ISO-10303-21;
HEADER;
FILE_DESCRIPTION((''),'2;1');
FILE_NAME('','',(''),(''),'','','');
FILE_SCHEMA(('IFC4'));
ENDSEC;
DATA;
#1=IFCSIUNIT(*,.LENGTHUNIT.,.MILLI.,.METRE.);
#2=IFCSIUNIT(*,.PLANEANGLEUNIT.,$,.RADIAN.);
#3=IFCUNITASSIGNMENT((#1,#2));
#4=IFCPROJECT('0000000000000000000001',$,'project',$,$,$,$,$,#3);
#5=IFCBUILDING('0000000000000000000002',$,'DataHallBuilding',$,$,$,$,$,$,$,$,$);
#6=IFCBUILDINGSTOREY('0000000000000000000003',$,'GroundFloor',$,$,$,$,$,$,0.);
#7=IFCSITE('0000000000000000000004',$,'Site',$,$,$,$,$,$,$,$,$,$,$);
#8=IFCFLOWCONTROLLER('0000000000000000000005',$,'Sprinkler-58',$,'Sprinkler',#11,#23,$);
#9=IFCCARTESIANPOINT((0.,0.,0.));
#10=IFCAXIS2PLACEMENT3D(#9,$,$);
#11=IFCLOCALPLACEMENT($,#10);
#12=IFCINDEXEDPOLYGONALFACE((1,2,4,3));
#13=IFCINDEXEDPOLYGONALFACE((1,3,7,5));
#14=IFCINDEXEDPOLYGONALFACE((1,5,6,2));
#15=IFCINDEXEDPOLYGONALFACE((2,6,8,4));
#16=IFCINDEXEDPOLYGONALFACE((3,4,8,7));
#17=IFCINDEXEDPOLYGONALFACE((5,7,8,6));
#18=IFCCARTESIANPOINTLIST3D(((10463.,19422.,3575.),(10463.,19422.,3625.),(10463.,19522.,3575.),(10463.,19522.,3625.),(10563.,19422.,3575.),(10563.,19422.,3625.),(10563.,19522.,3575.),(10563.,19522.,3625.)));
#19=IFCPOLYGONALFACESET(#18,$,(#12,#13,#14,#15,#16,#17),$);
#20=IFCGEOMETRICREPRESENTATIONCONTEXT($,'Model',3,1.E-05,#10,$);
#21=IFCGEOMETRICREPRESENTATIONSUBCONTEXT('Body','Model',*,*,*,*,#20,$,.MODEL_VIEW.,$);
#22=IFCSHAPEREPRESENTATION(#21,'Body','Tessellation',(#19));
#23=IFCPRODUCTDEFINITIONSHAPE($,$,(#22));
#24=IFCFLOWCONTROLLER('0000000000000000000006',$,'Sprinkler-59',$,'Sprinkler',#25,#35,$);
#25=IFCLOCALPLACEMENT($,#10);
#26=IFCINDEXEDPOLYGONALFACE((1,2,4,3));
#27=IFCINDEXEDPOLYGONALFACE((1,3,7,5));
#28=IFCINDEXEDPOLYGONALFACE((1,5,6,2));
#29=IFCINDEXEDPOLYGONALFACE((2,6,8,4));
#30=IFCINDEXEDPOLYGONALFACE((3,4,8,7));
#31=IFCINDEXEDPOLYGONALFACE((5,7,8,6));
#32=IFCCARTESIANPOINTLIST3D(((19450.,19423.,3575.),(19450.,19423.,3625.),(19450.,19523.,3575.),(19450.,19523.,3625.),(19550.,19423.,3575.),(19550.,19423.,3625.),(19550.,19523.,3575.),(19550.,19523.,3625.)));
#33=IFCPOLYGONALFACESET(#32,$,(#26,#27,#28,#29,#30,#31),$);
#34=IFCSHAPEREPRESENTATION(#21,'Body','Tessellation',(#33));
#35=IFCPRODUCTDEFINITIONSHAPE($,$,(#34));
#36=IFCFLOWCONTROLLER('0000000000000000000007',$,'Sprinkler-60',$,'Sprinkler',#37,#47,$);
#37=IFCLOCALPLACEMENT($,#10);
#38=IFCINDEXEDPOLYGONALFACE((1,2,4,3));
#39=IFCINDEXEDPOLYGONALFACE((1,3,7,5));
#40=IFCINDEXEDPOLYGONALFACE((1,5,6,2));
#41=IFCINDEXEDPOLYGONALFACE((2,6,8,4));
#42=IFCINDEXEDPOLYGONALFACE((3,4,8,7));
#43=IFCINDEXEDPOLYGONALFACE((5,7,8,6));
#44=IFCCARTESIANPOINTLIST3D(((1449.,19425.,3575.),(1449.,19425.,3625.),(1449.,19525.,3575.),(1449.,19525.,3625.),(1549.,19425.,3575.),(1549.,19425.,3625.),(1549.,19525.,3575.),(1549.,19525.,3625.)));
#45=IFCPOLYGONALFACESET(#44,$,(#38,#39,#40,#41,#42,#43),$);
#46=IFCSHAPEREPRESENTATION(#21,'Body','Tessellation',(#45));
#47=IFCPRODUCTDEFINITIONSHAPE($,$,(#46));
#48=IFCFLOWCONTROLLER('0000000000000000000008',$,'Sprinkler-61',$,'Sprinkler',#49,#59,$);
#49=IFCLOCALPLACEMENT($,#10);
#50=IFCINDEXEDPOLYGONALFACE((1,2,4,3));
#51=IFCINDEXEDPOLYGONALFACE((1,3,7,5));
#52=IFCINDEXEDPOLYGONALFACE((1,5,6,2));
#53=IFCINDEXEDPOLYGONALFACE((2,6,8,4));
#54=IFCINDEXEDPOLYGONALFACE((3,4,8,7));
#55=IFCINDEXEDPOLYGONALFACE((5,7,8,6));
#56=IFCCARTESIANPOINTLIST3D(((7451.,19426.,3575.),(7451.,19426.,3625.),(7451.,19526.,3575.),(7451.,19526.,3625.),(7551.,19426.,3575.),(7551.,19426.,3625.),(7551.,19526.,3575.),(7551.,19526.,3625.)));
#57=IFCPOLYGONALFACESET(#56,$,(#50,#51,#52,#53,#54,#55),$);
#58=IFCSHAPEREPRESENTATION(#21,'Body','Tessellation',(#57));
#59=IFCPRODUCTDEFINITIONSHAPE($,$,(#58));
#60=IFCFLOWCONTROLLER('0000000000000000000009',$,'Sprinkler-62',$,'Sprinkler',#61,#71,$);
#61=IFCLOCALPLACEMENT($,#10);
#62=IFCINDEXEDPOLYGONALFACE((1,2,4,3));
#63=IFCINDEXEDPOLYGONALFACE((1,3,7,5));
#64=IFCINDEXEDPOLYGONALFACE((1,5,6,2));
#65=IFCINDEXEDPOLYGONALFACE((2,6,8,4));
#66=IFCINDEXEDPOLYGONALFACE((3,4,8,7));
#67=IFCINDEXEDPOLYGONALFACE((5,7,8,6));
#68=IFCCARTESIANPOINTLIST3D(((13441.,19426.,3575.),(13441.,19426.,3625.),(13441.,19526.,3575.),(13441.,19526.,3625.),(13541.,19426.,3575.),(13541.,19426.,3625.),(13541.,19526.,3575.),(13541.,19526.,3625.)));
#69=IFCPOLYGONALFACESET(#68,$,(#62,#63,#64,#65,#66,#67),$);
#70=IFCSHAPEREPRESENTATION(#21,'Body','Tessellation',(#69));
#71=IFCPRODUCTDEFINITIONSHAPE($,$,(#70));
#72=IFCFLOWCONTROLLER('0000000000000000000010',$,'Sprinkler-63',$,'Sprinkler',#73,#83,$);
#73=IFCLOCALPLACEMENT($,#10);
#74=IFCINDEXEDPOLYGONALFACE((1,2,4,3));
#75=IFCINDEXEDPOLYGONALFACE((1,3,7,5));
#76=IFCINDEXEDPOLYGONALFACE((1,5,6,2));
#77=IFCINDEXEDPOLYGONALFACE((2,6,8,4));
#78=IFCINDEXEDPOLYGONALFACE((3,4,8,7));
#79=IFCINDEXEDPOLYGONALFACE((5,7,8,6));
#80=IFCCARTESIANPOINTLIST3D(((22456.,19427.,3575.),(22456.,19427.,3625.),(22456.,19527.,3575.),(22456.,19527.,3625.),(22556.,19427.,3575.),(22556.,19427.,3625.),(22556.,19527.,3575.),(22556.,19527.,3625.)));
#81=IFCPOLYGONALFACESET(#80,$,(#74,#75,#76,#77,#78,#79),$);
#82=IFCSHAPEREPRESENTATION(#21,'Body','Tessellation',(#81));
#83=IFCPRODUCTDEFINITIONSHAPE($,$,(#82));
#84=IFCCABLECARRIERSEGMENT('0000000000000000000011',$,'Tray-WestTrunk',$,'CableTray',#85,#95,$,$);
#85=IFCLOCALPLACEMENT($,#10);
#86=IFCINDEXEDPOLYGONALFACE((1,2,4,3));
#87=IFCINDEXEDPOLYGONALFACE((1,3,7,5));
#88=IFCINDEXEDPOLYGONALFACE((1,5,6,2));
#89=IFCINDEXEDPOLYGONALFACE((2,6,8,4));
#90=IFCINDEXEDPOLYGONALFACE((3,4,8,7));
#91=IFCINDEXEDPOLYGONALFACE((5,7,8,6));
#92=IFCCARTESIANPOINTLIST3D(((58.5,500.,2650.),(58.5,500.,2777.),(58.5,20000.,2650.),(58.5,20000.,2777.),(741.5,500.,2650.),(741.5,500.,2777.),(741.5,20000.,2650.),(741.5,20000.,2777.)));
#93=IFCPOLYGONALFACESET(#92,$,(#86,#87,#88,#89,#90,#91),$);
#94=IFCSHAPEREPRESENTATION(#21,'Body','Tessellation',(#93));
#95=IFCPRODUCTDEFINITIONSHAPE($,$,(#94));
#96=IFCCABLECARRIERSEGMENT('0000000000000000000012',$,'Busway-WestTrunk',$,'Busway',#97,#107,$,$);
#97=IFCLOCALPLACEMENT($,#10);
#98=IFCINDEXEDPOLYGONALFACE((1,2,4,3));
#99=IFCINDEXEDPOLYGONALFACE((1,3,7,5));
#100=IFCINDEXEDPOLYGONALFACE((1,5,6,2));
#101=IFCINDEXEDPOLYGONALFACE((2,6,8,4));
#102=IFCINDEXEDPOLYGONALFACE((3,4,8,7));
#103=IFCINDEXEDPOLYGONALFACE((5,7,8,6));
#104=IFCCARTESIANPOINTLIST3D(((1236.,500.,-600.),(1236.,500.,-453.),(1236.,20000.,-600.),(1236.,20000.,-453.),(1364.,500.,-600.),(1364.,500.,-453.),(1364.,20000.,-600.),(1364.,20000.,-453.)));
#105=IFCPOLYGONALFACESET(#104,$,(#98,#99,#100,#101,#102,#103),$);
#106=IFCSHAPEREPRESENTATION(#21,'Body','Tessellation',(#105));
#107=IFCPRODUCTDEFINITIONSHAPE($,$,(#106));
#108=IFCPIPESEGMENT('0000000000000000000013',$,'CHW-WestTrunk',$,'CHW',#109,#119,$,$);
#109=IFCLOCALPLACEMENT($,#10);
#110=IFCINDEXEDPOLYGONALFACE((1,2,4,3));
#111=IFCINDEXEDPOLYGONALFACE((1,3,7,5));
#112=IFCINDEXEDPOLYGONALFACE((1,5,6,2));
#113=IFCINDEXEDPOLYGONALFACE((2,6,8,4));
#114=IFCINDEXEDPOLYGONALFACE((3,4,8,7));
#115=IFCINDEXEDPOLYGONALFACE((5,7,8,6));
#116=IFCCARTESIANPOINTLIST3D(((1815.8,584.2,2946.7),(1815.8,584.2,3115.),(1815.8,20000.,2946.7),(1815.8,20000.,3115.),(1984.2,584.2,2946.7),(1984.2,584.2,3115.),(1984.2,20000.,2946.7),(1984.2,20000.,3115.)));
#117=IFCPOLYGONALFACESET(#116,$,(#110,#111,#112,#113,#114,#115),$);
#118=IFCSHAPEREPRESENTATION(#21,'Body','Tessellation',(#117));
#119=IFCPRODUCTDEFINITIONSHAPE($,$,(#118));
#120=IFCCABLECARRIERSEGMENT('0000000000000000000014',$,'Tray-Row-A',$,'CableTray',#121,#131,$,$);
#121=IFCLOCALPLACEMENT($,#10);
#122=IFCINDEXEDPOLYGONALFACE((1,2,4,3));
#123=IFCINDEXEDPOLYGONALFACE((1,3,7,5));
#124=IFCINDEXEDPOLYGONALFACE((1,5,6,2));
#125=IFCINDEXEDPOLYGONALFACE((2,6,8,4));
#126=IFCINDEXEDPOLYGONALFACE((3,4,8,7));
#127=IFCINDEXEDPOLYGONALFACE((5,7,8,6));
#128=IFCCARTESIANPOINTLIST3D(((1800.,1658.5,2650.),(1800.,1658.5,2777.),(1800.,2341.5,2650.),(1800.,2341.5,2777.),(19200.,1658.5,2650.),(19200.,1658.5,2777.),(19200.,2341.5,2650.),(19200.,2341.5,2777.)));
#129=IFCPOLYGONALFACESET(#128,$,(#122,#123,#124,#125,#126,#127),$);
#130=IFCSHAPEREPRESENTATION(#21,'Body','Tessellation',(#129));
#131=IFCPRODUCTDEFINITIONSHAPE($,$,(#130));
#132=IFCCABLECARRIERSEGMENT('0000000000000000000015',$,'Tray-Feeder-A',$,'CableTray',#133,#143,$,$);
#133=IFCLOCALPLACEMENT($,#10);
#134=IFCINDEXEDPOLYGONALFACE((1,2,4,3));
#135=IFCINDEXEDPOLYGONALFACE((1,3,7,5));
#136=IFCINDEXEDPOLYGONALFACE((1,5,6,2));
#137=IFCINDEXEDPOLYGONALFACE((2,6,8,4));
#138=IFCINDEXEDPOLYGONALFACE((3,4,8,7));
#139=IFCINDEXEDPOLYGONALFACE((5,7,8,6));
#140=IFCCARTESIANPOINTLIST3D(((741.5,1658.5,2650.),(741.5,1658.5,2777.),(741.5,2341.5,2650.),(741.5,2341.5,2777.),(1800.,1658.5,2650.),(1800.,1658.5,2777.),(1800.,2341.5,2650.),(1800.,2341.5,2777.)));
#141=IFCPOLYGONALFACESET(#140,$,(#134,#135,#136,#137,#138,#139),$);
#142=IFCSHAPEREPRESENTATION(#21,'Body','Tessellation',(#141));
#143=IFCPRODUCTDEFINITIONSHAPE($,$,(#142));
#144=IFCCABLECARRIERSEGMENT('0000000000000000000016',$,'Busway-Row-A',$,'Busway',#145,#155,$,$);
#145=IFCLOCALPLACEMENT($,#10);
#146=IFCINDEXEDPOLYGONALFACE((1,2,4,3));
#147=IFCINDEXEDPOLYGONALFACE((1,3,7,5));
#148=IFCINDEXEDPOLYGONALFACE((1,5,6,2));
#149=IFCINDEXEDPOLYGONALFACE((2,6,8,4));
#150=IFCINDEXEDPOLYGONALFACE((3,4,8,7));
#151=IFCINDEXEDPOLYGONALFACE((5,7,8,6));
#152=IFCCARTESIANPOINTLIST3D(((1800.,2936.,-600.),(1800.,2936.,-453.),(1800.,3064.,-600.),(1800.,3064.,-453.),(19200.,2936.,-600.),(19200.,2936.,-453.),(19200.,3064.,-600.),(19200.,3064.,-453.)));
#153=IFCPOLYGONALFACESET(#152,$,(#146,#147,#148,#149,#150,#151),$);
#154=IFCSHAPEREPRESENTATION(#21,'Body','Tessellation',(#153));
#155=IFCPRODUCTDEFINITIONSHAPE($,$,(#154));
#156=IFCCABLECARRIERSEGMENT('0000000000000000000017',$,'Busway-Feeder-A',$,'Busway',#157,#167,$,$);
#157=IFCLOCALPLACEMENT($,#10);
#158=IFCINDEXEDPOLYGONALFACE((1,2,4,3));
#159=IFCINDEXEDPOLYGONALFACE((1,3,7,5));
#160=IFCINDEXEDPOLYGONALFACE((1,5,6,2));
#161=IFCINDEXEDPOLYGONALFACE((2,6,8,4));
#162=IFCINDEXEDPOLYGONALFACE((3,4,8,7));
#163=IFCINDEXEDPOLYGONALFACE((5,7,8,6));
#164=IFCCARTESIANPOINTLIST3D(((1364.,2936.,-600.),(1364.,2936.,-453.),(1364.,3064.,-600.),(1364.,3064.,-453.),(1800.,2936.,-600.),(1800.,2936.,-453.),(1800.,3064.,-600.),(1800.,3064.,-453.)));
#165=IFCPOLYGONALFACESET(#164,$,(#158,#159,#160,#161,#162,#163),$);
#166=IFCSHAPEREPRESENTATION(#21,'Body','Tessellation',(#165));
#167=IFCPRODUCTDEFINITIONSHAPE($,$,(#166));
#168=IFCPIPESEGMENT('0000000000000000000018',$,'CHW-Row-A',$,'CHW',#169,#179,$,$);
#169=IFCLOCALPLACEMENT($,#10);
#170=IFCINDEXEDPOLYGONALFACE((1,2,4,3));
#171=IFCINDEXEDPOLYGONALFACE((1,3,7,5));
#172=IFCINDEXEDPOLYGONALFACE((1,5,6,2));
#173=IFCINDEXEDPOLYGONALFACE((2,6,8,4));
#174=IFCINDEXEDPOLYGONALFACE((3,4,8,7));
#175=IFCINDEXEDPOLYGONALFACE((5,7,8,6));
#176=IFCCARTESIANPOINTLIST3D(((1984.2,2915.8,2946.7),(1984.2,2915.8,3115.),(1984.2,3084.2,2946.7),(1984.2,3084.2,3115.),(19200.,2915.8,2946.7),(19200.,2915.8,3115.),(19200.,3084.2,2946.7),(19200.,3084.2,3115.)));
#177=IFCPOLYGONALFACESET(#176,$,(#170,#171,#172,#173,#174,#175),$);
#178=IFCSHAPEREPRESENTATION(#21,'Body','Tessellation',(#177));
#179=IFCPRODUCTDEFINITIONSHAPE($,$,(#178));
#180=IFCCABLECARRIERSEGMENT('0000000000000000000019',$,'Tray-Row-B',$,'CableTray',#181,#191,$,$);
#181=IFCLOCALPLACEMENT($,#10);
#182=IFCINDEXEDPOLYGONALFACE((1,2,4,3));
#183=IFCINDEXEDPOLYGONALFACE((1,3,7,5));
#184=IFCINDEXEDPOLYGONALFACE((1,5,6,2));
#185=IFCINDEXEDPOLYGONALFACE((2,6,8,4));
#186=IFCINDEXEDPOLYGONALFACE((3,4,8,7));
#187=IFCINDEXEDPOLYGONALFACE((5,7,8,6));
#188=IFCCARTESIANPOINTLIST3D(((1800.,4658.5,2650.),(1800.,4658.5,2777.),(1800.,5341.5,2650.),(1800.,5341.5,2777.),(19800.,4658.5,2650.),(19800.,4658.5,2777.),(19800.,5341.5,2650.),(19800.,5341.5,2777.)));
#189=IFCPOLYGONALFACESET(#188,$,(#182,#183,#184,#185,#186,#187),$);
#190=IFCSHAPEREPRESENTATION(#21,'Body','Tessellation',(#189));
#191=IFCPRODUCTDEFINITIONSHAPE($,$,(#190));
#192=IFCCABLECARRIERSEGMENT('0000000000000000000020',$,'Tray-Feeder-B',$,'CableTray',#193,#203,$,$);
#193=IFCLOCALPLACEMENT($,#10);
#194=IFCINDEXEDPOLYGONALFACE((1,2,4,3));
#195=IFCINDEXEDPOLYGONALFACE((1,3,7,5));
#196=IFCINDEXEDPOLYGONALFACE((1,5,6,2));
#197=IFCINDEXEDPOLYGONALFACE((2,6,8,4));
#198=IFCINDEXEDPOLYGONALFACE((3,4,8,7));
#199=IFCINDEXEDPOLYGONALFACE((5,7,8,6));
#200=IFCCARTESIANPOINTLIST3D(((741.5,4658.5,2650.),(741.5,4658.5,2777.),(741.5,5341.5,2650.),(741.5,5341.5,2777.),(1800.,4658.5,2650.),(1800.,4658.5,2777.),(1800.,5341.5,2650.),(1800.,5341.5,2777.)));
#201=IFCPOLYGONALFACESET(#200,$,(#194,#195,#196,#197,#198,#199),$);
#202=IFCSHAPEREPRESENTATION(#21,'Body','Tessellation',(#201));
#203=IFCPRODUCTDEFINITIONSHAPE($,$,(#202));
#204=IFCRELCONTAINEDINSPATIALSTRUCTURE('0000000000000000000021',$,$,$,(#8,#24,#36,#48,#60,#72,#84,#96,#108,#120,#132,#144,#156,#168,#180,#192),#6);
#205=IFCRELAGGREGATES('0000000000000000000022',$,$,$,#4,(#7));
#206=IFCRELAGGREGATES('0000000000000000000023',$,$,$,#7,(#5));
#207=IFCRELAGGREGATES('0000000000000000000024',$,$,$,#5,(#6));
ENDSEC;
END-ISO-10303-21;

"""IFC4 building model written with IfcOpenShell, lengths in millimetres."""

from ifc_helpers import new_model, si_unit, frame, origin, place, context, subcontext, project, spatial, rectangle, extrude, element, save


model = new_model("IFC4")

# Units and contexts
model_context = context("Model", 3, precision=1e-05, world=origin())
body_context = subcontext(model_context, "Body", "Model", "MODEL_VIEW")
ifc_project = project(units=[si_unit("LENGTHUNIT", "METRE", prefix="MILLI"), si_unit("PLANEANGLEUNIT", "RADIAN")])

# Site, building, storey
site = spatial("IfcSite", under=ifc_project, Name="Site")
building = spatial("IfcBuilding", under=site, Name="DataHallBuilding")
storey = spatial("IfcBuildingStorey", under=building, Name="GroundFloor", Elevation=0.0)

# Flow controllers
flow_controller_1_placement = place(None, origin())
element("IfcFlowController", 1, at=flow_controller_1_placement, inside=storey, Name="Sprinkler-58", ObjectType="Sprinkler", context=body_context, shape_type="SweptSolid", body=[
    extrude(rectangle(XDim=100.0, YDim=100.0), frame((10513.0, 19472.0, 3575.0), z_axis=(0.0, 0.0, 1.0), x_axis=(1.0, 0.0, 0.0)), (0.0, 0.0, 1.0), 50.0),
])
flow_controller_2_placement = place(None, origin())
element("IfcFlowController", 2, at=flow_controller_2_placement, inside=storey, Name="Sprinkler-59", ObjectType="Sprinkler", context=body_context, shape_type="SweptSolid", body=[
    extrude(rectangle(XDim=100.0, YDim=100.0), frame((19500.0, 19473.0, 3575.0), z_axis=(0.0, 0.0, 1.0), x_axis=(1.0, 0.0, 0.0)), (0.0, 0.0, 1.0), 50.0),
])
flow_controller_3_placement = place(None, origin())
element("IfcFlowController", 3, at=flow_controller_3_placement, inside=storey, Name="Sprinkler-60", ObjectType="Sprinkler", context=body_context, shape_type="SweptSolid", body=[
    extrude(rectangle(XDim=100.0, YDim=100.0), frame((1499.0, 19475.0, 3575.0), z_axis=(0.0, 0.0, 1.0), x_axis=(1.0, 0.0, 0.0)), (0.0, 0.0, 1.0), 50.0),
])
flow_controller_4_placement = place(None, origin())
element("IfcFlowController", 4, at=flow_controller_4_placement, inside=storey, Name="Sprinkler-61", ObjectType="Sprinkler", context=body_context, shape_type="SweptSolid", body=[
    extrude(rectangle(XDim=100.0, YDim=100.0), frame((7501.0, 19476.0, 3575.0), z_axis=(0.0, 0.0, 1.0), x_axis=(1.0, 0.0, 0.0)), (0.0, 0.0, 1.0), 50.0),
])
flow_controller_5_placement = place(None, origin())
element("IfcFlowController", 5, at=flow_controller_5_placement, inside=storey, Name="Sprinkler-62", ObjectType="Sprinkler", context=body_context, shape_type="SweptSolid", body=[
    extrude(rectangle(XDim=100.0, YDim=100.0), frame((13491.0, 19476.0, 3575.0), z_axis=(0.0, 0.0, 1.0), x_axis=(1.0, 0.0, 0.0)), (0.0, 0.0, 1.0), 50.0),
])
flow_controller_6_placement = place(None, origin())
element("IfcFlowController", 6, at=flow_controller_6_placement, inside=storey, Name="Sprinkler-63", ObjectType="Sprinkler", context=body_context, shape_type="SweptSolid", body=[
    extrude(rectangle(XDim=100.0, YDim=100.0), frame((22506.0, 19477.0, 3575.0), z_axis=(0.0, 0.0, 1.0), x_axis=(1.0, 0.0, 0.0)), (0.0, 0.0, 1.0), 50.0),
])

# Cable carrier segments
cable_carrier_segment_1_placement = place(None, origin())
element("IfcCableCarrierSegment", 7, at=cable_carrier_segment_1_placement, inside=storey, Name="Tray-WestTrunk", ObjectType="CableTray", context=body_context, shape_type="SweptSolid", body=[
    extrude(rectangle(XDim=683.0, YDim=19500.0), frame((400.0, 10250.0, 2650.0), z_axis=(0.0, 0.0, 1.0), x_axis=(1.0, 0.0, 0.0)), (0.0, 0.0, 1.0), 127.0),
])
cable_carrier_segment_2_placement = place(None, origin())
element("IfcCableCarrierSegment", 8, at=cable_carrier_segment_2_placement, inside=storey, Name="Busway-WestTrunk", ObjectType="Busway", context=body_context, shape_type="SweptSolid", body=[
    extrude(rectangle(XDim=128.0, YDim=19500.0), frame((1300.0, 10250.0, -600.0), z_axis=(0.0, 0.0, 1.0), x_axis=(1.0, 0.0, 0.0)), (0.0, 0.0, 1.0), 147.0),
])

# Pipe segment
pipe_segment_1_placement = place(None, origin())
element("IfcPipeSegment", 9, at=pipe_segment_1_placement, inside=storey, Name="CHW-WestTrunk", ObjectType="CHW", context=body_context, shape_type="SweptSolid", body=[
    extrude(rectangle(XDim=168.3, YDim=19415.8), frame((1900.0, 10292.1, 2946.7), z_axis=(0.0, 0.0, 1.0), x_axis=(1.0, 0.0, 0.0)), (0.0, 0.0, 1.0), 168.3),
])

# Cable carrier segments
cable_carrier_segment_3_placement = place(None, origin())
element("IfcCableCarrierSegment", 10, at=cable_carrier_segment_3_placement, inside=storey, Name="Tray-Row-A", ObjectType="CableTray", context=body_context, shape_type="SweptSolid", body=[
    extrude(rectangle(XDim=17400.0, YDim=683.0), frame((10500.0, 2000.0, 2650.0), z_axis=(0.0, 0.0, 1.0), x_axis=(1.0, 0.0, 0.0)), (0.0, 0.0, 1.0), 127.0),
])
cable_carrier_segment_4_placement = place(None, origin())
element("IfcCableCarrierSegment", 11, at=cable_carrier_segment_4_placement, inside=storey, Name="Tray-Feeder-A", ObjectType="CableTray", context=body_context, shape_type="SweptSolid", body=[
    extrude(rectangle(XDim=1058.5, YDim=683.0), frame((1270.8, 2000.0, 2650.0), z_axis=(0.0, 0.0, 1.0), x_axis=(1.0, 0.0, 0.0)), (0.0, 0.0, 1.0), 127.0),
])
cable_carrier_segment_5_placement = place(None, origin())
element("IfcCableCarrierSegment", 12, at=cable_carrier_segment_5_placement, inside=storey, Name="Busway-Row-A", ObjectType="Busway", context=body_context, shape_type="SweptSolid", body=[
    extrude(rectangle(XDim=17400.0, YDim=128.0), frame((10500.0, 3000.0, -600.0), z_axis=(0.0, 0.0, 1.0), x_axis=(1.0, 0.0, 0.0)), (0.0, 0.0, 1.0), 147.0),
])
cable_carrier_segment_6_placement = place(None, origin())
element("IfcCableCarrierSegment", 13, at=cable_carrier_segment_6_placement, inside=storey, Name="Busway-Feeder-A", ObjectType="Busway", context=body_context, shape_type="SweptSolid", body=[
    extrude(rectangle(XDim=436.0, YDim=128.0), frame((1582.0, 3000.0, -600.0), z_axis=(0.0, 0.0, 1.0), x_axis=(1.0, 0.0, 0.0)), (0.0, 0.0, 1.0), 147.0),
])

# Pipe segment
pipe_segment_2_placement = place(None, origin())
element("IfcPipeSegment", 14, at=pipe_segment_2_placement, inside=storey, Name="CHW-Row-A", ObjectType="CHW", context=body_context, shape_type="SweptSolid", body=[
    extrude(rectangle(XDim=17215.8, YDim=168.3), frame((10592.1, 3000.0, 2946.7), z_axis=(0.0, 0.0, 1.0), x_axis=(1.0, 0.0, 0.0)), (0.0, 0.0, 1.0), 168.3),
])

# Cable carrier segments
cable_carrier_segment_7_placement = place(None, origin())
element("IfcCableCarrierSegment", 15, at=cable_carrier_segment_7_placement, inside=storey, Name="Tray-Row-B", ObjectType="CableTray", context=body_context, shape_type="SweptSolid", body=[
    extrude(rectangle(XDim=18000.0, YDim=683.0), frame((10800.0, 5000.0, 2650.0), z_axis=(0.0, 0.0, 1.0), x_axis=(1.0, 0.0, 0.0)), (0.0, 0.0, 1.0), 127.0),
])
cable_carrier_segment_8_placement = place(None, origin())
element("IfcCableCarrierSegment", 16, at=cable_carrier_segment_8_placement, inside=storey, Name="Tray-Feeder-B", ObjectType="CableTray", context=body_context, shape_type="SweptSolid", body=[
    extrude(rectangle(XDim=1058.5, YDim=683.0), frame((1270.8, 5000.0, 2650.0), z_axis=(0.0, 0.0, 1.0), x_axis=(1.0, 0.0, 0.0)), (0.0, 0.0, 1.0), 127.0),
])

save(model, "model.ifc")
